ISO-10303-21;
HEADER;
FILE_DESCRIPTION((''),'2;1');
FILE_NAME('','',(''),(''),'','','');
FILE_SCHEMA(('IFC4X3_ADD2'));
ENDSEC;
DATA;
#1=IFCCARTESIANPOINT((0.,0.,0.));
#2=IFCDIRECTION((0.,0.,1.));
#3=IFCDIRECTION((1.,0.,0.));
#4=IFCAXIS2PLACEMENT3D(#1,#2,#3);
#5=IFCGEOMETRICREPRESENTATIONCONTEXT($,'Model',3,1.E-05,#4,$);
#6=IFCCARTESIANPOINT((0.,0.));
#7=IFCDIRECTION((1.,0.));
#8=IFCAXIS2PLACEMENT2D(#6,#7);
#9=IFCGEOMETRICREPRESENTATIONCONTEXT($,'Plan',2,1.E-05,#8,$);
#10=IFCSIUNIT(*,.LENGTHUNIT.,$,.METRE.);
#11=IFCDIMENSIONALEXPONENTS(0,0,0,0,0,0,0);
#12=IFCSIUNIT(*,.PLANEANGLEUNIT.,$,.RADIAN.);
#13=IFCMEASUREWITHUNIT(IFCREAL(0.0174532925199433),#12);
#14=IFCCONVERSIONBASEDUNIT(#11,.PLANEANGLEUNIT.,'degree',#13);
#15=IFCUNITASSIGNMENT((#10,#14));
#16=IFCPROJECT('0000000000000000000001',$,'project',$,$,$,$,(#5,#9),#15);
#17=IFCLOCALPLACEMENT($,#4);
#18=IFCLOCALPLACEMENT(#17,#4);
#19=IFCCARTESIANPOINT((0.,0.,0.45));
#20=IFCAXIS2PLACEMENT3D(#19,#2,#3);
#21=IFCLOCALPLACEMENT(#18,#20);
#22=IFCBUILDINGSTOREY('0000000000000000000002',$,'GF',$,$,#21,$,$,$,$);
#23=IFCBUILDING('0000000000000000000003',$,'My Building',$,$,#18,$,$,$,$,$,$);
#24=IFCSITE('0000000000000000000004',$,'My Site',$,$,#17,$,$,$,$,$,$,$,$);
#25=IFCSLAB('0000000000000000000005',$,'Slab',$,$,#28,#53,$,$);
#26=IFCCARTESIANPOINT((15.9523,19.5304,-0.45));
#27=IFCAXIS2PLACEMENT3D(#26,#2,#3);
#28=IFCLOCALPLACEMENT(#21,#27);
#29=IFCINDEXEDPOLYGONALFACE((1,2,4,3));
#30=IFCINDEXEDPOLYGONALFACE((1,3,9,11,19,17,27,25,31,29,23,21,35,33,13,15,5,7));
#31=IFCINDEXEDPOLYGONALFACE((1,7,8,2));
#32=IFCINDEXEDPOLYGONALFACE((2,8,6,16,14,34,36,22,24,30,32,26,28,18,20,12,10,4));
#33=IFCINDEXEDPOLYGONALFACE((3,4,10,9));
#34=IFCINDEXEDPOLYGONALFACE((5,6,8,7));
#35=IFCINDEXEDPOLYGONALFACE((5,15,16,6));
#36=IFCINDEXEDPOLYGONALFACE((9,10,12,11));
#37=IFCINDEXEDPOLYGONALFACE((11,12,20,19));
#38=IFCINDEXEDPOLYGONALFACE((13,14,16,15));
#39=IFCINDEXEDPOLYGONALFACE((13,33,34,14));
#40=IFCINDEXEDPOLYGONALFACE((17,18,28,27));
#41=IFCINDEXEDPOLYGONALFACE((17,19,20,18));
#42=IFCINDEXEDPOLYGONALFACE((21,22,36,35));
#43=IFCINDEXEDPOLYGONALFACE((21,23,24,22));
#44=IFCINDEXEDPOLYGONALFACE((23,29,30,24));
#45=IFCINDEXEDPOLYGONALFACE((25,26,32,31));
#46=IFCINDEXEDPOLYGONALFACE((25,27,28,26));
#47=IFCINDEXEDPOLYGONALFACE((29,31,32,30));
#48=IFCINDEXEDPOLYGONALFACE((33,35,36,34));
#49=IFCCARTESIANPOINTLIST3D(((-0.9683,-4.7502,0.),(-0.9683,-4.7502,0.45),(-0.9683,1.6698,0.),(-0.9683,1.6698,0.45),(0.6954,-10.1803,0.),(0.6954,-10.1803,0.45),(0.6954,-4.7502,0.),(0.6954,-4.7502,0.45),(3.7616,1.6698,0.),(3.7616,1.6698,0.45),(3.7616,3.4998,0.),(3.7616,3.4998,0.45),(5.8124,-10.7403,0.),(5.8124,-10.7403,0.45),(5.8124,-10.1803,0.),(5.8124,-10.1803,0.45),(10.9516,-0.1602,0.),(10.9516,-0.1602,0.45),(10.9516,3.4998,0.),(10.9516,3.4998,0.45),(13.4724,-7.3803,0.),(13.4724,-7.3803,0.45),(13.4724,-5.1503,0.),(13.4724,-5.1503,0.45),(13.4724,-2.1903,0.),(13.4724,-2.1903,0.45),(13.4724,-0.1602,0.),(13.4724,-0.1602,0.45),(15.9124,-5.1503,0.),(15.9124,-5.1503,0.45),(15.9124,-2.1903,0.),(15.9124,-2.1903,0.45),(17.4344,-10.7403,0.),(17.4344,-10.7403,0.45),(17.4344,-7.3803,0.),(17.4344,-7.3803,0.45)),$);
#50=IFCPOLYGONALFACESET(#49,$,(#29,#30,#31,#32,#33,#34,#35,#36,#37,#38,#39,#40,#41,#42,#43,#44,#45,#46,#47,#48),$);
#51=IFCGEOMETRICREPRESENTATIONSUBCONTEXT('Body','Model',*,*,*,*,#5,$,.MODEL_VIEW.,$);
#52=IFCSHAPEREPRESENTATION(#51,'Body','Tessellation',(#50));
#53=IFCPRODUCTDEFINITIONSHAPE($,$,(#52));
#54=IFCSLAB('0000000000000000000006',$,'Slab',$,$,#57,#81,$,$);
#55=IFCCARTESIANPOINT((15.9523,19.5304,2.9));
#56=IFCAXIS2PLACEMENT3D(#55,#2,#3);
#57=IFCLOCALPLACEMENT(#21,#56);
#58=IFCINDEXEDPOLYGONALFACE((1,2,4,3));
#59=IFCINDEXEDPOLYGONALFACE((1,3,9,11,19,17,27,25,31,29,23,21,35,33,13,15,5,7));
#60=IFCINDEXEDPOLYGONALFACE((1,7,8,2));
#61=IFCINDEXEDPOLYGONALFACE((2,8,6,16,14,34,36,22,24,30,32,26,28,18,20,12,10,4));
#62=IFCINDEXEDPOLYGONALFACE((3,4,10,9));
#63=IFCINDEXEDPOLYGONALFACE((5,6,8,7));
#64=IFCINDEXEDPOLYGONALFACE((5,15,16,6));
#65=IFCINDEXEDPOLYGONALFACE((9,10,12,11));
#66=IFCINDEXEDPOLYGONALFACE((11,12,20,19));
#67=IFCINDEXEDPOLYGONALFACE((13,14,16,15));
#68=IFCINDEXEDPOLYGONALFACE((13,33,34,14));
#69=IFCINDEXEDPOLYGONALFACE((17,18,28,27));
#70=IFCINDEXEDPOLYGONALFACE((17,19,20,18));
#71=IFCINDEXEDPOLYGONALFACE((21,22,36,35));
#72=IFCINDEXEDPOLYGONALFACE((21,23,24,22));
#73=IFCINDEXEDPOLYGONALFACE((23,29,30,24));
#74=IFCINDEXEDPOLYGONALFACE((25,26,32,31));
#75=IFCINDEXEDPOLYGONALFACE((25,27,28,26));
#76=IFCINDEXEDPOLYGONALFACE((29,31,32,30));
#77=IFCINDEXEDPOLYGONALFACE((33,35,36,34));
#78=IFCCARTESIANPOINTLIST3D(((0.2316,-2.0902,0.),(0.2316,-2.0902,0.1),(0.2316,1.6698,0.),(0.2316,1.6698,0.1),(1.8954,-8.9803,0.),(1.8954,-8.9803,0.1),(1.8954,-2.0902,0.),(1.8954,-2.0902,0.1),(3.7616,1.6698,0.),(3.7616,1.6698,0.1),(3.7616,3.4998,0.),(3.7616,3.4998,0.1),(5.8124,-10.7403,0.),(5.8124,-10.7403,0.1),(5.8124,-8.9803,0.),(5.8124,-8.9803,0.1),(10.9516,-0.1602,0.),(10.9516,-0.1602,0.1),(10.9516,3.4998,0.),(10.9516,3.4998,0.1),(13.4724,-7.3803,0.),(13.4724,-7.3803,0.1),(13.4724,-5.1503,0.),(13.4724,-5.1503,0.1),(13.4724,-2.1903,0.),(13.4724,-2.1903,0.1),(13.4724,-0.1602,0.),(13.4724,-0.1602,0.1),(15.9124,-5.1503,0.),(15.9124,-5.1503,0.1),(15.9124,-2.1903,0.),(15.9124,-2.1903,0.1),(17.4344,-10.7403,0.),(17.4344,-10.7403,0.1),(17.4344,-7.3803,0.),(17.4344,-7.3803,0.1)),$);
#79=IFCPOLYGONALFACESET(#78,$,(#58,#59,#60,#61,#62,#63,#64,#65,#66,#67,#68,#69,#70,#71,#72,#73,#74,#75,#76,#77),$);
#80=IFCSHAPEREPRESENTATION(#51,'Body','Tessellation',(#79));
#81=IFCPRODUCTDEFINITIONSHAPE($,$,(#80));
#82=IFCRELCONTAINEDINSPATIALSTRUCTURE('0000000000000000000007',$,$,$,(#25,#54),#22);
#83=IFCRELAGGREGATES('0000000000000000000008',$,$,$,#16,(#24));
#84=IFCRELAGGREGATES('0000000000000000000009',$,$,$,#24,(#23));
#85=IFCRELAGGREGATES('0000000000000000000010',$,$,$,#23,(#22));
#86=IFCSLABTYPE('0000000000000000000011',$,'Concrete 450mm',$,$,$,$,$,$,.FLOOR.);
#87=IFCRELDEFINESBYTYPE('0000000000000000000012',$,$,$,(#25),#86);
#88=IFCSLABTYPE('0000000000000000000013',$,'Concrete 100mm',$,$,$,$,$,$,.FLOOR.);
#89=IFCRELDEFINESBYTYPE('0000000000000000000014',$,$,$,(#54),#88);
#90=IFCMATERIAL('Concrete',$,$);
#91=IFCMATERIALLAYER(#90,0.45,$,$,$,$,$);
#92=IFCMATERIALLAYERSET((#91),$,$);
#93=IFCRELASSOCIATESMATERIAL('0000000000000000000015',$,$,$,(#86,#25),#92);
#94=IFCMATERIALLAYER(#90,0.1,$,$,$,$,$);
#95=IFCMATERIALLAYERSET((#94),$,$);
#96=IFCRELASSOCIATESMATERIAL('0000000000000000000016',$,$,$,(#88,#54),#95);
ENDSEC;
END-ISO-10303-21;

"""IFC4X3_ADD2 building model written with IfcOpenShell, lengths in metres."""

from ifc_helpers import new_model, entity, si_unit, converted_unit, frame, origin_with_axes, origin_2d_with_axis, place, context, subcontext, project, spatial, line, indexed_curve, outline, extrude, material, layer, layer_set, layer_usage, type_object, element, save


model = new_model("IFC4X3_ADD2")

# Units and contexts
model_context = context("Model", 3, precision=1e-05, world=origin_with_axes())
plan_context = context("Plan", 2, precision=1e-05, world=origin_2d_with_axis())
body_context = subcontext(model_context, "Body", "Model", "MODEL_VIEW")
ifc_project = project(units=[si_unit("LENGTHUNIT", "METRE"), converted_unit("PLANEANGLEUNIT", "degree", entity("IfcReal", 0.0174532925199433), si_unit("PLANEANGLEUNIT", "RADIAN"), dimensions=[0, 0, 0, 0, 0, 0, 0])], contexts=[model_context, plan_context])

# Site, building, storey
site_placement = place(None, origin_with_axes())
site = spatial("IfcSite", under=ifc_project, at=site_placement, Name="My Site")
building_placement = place(site_placement, origin_with_axes())
building = spatial("IfcBuilding", under=site, at=building_placement, Name="My Building")
storey_placement = place(building_placement, frame((0.0, 0.0, 0.45), z_axis=(0.0, 0.0, 1.0), x_axis=(1.0, 0.0, 0.0)))
storey = spatial("IfcBuildingStorey", under=building, at=storey_placement, Name="GF")

# Slabs
ifc_material_1 = material(Name="Concrete")
ifc_layer_1 = layer(ifc_material_1, 0.45)
ifc_layer_set_1 = layer_set([ifc_layer_1])
ifc_layer_usage_1 = layer_usage(ifc_layer_set_1, "AXIS3", "POSITIVE", 0.0)
slab_type_1 = type_object("IfcSlabType", Name="Concrete 450mm", PredefinedType="FLOOR", material=ifc_layer_set_1)
slab_1_placement = place(storey_placement, frame((15.9523, 19.5304, -0.45), z_axis=(0.0, 0.0, 1.0), x_axis=(1.0, 0.0, 0.0)))
element("IfcSlab", 1, at=slab_1_placement, inside=storey, type_object=slab_type_1, material=ifc_layer_usage_1, Name="Slab", context=body_context, shape_type="SweptSolid", body=[
    extrude(outline(indexed_curve([(13.4724, -5.1503), (15.9124, -5.1503), (15.9124, -2.1903), (13.4724, -2.1903), (13.4724, -0.1602), (10.9516, -0.1602), (10.9516, 3.4998), (3.7616, 3.4998), (3.7616, 1.6698), (-0.9683, 1.6698), (-0.9683, -4.7502), (0.6954, -4.7502), (0.6954, -10.1803), (5.8124, -10.1803), (5.8124, -10.7403), (17.4344, -10.7403), (17.4344, -7.3803), (13.4724, -7.3803)], segments=[line(3, 4), line(4, 5), line(5, 6), line(6, 7), line(7, 8), line(8, 9), line(9, 10), line(10, 11), line(11, 12), line(12, 13), line(13, 14), line(14, 15), line(15, 16), line(16, 17), line(17, 18), line(18, 1), line(1, 2), line(2, 3)], self_intersect=False)), None, (0.0, 0.0, 1.0), 0.45),
])
ifc_layer_2 = layer(ifc_material_1, 0.1)
ifc_layer_set_2 = layer_set([ifc_layer_2])
ifc_layer_usage_2 = layer_usage(ifc_layer_set_2, "AXIS3", "POSITIVE", 0.0)
slab_type_2 = type_object("IfcSlabType", Name="Concrete 100mm", PredefinedType="FLOOR", material=ifc_layer_set_2)
slab_2_placement = place(storey_placement, frame((15.9523, 19.5304, 2.9), z_axis=(0.0, 0.0, 1.0), x_axis=(1.0, 0.0, 0.0)))
element("IfcSlab", 2, at=slab_2_placement, inside=storey, type_object=slab_type_2, material=ifc_layer_usage_2, Name="Slab", context=body_context, shape_type="SweptSolid", body=[
    extrude(outline(indexed_curve([(10.9516, 3.4998), (10.9516, -0.1602), (13.4724, -0.1602), (13.4724, -2.1903), (15.9124, -2.1903), (15.9124, -5.1503), (13.4724, -5.1503), (13.4724, -7.3803), (17.4344, -7.3803), (17.4344, -10.7403), (5.8124, -10.7403), (5.8124, -8.9803), (1.8954, -8.9803), (1.8954, -2.0902), (0.2316, -2.0902), (0.2316, 1.6698), (3.7616, 1.6698), (3.7616, 3.4998)], segments=[line(12, 11), line(11, 10), line(10, 9), line(9, 8), line(8, 7), line(7, 6), line(6, 5), line(5, 4), line(4, 3), line(3, 2), line(2, 1), line(1, 18), line(18, 17), line(17, 16), line(16, 15), line(15, 14), line(14, 13), line(13, 12)], self_intersect=False)), None, (0.0, 0.0, 1.0), 0.1),
])

save(model, "model.ifc")
